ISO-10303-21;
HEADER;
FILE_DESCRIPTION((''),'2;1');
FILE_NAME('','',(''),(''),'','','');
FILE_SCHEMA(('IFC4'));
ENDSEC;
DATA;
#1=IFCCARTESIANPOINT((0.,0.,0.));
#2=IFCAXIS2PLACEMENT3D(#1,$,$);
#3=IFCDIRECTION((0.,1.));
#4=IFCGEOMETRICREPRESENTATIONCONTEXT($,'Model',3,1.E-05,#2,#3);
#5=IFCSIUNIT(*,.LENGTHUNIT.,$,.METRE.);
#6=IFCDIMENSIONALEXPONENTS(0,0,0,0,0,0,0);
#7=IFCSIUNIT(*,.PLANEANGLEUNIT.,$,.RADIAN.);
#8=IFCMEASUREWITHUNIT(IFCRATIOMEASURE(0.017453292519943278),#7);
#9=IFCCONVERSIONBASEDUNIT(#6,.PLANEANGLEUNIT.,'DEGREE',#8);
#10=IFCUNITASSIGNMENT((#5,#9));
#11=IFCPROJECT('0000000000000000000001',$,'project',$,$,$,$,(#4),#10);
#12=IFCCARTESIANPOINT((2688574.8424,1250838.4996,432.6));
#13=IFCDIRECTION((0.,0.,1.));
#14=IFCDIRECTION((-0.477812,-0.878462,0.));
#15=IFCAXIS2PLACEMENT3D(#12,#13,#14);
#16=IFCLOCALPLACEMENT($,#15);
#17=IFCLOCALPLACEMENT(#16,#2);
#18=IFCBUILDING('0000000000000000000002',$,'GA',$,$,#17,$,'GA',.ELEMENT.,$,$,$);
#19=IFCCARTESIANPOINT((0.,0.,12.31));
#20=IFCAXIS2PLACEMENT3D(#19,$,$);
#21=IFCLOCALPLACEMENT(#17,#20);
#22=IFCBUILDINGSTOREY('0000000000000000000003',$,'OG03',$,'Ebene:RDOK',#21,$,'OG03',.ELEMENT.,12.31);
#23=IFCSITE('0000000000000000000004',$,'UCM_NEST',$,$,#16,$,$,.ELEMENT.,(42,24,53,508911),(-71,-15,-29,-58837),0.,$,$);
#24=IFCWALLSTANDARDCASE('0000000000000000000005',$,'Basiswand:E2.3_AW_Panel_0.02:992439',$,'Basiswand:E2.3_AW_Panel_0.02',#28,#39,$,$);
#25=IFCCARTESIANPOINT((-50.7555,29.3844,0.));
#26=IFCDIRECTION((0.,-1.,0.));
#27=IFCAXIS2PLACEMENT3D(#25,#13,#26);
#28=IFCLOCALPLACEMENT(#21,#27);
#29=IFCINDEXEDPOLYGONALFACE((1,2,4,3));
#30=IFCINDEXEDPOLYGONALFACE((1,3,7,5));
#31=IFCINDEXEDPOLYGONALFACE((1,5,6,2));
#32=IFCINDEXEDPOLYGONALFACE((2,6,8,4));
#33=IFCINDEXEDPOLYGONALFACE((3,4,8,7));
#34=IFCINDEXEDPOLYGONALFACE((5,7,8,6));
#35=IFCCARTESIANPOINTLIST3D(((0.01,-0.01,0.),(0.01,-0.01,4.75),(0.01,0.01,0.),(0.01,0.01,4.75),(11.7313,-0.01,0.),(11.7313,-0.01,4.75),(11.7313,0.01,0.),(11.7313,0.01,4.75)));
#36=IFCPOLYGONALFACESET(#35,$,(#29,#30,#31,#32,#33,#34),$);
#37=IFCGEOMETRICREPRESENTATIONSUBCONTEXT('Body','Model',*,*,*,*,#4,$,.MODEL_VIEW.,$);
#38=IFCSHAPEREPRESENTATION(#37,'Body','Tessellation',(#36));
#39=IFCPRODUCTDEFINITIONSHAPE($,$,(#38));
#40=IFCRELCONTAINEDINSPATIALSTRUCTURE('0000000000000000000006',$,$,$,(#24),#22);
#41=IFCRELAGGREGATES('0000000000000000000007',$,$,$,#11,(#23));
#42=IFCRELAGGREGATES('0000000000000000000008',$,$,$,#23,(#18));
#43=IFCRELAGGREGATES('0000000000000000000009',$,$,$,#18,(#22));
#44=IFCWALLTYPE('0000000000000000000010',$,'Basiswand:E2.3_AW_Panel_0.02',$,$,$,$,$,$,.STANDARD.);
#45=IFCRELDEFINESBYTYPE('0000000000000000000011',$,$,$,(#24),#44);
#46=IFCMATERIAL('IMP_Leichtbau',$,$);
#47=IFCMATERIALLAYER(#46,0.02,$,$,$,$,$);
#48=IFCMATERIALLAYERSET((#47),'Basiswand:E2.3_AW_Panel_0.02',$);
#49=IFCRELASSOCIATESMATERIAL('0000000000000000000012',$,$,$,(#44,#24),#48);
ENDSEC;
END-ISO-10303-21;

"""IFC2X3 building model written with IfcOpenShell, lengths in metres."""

from ifc_helpers import new_model, entity, si_unit, converted_unit, direction, frame, frame_2d, origin, place, context, subcontext, project, spatial, rectangle, extrude, material, layer, layer_set, layer_usage, type_object, element, save


model = new_model("IFC2X3")

# Units and contexts
model_context = context("Model", 3, precision=1e-05, world=origin(), true_north=direction((0.0, 1.0)))
body_context = subcontext(model_context, "Body", "Model", "MODEL_VIEW")
ifc_project = project(units=[si_unit("LENGTHUNIT", "METRE"), converted_unit("PLANEANGLEUNIT", "DEGREE", entity("IfcRatioMeasure", 0.017453292519943278), si_unit("PLANEANGLEUNIT", "RADIAN"), dimensions=[0, 0, 0, 0, 0, 0, 0])], contexts=[model_context])

# Site, building, storey
site_placement = place(None, frame((2688574.8424, 1250838.4996, 432.6), z_axis=(0.0, 0.0, 1.0), x_axis=(-0.477812, -0.878462, 0.0)))
site = spatial("IfcSite", under=ifc_project, at=site_placement, Name="UCM_NEST", CompositionType="ELEMENT", RefLatitude=(42, 24, 53, 508911), RefLongitude=(-71, -15, -29, -58837), RefElevation=0.0)
building_placement = place(site_placement, origin())
building = spatial("IfcBuilding", under=site, at=building_placement, Name="GA", LongName="GA", CompositionType="ELEMENT")
storey_placement = place(building_placement, frame((0.0, 0.0, 12.31)))
storey = spatial("IfcBuildingStorey", under=building, at=storey_placement, Name="OG03", ObjectType="Ebene:RDOK", LongName="OG03", CompositionType="ELEMENT", Elevation=12.31)

# Wall
ifc_material_1 = material(Name="IMP_Leichtbau")
ifc_layer_1 = layer(ifc_material_1, 0.02)
ifc_layer_set_1 = layer_set([ifc_layer_1], Name="Basiswand:E2.3_AW_Panel_0.02")
ifc_layer_usage_1 = layer_usage(ifc_layer_set_1, "AXIS2", "NEGATIVE", 0.01)
wall_type_1 = type_object("IfcWallType", Name="Basiswand:E2.3_AW_Panel_0.02", PredefinedType="STANDARD", material=ifc_layer_set_1)
wall_1_placement = place(storey_placement, frame((-50.7555, 29.3844, 0.0), z_axis=(0.0, 0.0, 1.0), x_axis=(0.0, -1.0, 0.0)))
element("IfcWallStandardCase", 1, at=wall_1_placement, inside=storey, type_object=wall_type_1, material=ifc_layer_usage_1, Name="Basiswand:E2.3_AW_Panel_0.02:992439", ObjectType="Basiswand:E2.3_AW_Panel_0.02", context=body_context, shape_type="SweptSolid", body=[
    extrude(rectangle(XDim=11.7213, YDim=0.02, at=frame_2d((5.8706, 0.0), x_axis=(-1.0, 0.0))), origin(), (0.0, 0.0, 1.0), 4.75),
])

save(model, "model.ifc")
